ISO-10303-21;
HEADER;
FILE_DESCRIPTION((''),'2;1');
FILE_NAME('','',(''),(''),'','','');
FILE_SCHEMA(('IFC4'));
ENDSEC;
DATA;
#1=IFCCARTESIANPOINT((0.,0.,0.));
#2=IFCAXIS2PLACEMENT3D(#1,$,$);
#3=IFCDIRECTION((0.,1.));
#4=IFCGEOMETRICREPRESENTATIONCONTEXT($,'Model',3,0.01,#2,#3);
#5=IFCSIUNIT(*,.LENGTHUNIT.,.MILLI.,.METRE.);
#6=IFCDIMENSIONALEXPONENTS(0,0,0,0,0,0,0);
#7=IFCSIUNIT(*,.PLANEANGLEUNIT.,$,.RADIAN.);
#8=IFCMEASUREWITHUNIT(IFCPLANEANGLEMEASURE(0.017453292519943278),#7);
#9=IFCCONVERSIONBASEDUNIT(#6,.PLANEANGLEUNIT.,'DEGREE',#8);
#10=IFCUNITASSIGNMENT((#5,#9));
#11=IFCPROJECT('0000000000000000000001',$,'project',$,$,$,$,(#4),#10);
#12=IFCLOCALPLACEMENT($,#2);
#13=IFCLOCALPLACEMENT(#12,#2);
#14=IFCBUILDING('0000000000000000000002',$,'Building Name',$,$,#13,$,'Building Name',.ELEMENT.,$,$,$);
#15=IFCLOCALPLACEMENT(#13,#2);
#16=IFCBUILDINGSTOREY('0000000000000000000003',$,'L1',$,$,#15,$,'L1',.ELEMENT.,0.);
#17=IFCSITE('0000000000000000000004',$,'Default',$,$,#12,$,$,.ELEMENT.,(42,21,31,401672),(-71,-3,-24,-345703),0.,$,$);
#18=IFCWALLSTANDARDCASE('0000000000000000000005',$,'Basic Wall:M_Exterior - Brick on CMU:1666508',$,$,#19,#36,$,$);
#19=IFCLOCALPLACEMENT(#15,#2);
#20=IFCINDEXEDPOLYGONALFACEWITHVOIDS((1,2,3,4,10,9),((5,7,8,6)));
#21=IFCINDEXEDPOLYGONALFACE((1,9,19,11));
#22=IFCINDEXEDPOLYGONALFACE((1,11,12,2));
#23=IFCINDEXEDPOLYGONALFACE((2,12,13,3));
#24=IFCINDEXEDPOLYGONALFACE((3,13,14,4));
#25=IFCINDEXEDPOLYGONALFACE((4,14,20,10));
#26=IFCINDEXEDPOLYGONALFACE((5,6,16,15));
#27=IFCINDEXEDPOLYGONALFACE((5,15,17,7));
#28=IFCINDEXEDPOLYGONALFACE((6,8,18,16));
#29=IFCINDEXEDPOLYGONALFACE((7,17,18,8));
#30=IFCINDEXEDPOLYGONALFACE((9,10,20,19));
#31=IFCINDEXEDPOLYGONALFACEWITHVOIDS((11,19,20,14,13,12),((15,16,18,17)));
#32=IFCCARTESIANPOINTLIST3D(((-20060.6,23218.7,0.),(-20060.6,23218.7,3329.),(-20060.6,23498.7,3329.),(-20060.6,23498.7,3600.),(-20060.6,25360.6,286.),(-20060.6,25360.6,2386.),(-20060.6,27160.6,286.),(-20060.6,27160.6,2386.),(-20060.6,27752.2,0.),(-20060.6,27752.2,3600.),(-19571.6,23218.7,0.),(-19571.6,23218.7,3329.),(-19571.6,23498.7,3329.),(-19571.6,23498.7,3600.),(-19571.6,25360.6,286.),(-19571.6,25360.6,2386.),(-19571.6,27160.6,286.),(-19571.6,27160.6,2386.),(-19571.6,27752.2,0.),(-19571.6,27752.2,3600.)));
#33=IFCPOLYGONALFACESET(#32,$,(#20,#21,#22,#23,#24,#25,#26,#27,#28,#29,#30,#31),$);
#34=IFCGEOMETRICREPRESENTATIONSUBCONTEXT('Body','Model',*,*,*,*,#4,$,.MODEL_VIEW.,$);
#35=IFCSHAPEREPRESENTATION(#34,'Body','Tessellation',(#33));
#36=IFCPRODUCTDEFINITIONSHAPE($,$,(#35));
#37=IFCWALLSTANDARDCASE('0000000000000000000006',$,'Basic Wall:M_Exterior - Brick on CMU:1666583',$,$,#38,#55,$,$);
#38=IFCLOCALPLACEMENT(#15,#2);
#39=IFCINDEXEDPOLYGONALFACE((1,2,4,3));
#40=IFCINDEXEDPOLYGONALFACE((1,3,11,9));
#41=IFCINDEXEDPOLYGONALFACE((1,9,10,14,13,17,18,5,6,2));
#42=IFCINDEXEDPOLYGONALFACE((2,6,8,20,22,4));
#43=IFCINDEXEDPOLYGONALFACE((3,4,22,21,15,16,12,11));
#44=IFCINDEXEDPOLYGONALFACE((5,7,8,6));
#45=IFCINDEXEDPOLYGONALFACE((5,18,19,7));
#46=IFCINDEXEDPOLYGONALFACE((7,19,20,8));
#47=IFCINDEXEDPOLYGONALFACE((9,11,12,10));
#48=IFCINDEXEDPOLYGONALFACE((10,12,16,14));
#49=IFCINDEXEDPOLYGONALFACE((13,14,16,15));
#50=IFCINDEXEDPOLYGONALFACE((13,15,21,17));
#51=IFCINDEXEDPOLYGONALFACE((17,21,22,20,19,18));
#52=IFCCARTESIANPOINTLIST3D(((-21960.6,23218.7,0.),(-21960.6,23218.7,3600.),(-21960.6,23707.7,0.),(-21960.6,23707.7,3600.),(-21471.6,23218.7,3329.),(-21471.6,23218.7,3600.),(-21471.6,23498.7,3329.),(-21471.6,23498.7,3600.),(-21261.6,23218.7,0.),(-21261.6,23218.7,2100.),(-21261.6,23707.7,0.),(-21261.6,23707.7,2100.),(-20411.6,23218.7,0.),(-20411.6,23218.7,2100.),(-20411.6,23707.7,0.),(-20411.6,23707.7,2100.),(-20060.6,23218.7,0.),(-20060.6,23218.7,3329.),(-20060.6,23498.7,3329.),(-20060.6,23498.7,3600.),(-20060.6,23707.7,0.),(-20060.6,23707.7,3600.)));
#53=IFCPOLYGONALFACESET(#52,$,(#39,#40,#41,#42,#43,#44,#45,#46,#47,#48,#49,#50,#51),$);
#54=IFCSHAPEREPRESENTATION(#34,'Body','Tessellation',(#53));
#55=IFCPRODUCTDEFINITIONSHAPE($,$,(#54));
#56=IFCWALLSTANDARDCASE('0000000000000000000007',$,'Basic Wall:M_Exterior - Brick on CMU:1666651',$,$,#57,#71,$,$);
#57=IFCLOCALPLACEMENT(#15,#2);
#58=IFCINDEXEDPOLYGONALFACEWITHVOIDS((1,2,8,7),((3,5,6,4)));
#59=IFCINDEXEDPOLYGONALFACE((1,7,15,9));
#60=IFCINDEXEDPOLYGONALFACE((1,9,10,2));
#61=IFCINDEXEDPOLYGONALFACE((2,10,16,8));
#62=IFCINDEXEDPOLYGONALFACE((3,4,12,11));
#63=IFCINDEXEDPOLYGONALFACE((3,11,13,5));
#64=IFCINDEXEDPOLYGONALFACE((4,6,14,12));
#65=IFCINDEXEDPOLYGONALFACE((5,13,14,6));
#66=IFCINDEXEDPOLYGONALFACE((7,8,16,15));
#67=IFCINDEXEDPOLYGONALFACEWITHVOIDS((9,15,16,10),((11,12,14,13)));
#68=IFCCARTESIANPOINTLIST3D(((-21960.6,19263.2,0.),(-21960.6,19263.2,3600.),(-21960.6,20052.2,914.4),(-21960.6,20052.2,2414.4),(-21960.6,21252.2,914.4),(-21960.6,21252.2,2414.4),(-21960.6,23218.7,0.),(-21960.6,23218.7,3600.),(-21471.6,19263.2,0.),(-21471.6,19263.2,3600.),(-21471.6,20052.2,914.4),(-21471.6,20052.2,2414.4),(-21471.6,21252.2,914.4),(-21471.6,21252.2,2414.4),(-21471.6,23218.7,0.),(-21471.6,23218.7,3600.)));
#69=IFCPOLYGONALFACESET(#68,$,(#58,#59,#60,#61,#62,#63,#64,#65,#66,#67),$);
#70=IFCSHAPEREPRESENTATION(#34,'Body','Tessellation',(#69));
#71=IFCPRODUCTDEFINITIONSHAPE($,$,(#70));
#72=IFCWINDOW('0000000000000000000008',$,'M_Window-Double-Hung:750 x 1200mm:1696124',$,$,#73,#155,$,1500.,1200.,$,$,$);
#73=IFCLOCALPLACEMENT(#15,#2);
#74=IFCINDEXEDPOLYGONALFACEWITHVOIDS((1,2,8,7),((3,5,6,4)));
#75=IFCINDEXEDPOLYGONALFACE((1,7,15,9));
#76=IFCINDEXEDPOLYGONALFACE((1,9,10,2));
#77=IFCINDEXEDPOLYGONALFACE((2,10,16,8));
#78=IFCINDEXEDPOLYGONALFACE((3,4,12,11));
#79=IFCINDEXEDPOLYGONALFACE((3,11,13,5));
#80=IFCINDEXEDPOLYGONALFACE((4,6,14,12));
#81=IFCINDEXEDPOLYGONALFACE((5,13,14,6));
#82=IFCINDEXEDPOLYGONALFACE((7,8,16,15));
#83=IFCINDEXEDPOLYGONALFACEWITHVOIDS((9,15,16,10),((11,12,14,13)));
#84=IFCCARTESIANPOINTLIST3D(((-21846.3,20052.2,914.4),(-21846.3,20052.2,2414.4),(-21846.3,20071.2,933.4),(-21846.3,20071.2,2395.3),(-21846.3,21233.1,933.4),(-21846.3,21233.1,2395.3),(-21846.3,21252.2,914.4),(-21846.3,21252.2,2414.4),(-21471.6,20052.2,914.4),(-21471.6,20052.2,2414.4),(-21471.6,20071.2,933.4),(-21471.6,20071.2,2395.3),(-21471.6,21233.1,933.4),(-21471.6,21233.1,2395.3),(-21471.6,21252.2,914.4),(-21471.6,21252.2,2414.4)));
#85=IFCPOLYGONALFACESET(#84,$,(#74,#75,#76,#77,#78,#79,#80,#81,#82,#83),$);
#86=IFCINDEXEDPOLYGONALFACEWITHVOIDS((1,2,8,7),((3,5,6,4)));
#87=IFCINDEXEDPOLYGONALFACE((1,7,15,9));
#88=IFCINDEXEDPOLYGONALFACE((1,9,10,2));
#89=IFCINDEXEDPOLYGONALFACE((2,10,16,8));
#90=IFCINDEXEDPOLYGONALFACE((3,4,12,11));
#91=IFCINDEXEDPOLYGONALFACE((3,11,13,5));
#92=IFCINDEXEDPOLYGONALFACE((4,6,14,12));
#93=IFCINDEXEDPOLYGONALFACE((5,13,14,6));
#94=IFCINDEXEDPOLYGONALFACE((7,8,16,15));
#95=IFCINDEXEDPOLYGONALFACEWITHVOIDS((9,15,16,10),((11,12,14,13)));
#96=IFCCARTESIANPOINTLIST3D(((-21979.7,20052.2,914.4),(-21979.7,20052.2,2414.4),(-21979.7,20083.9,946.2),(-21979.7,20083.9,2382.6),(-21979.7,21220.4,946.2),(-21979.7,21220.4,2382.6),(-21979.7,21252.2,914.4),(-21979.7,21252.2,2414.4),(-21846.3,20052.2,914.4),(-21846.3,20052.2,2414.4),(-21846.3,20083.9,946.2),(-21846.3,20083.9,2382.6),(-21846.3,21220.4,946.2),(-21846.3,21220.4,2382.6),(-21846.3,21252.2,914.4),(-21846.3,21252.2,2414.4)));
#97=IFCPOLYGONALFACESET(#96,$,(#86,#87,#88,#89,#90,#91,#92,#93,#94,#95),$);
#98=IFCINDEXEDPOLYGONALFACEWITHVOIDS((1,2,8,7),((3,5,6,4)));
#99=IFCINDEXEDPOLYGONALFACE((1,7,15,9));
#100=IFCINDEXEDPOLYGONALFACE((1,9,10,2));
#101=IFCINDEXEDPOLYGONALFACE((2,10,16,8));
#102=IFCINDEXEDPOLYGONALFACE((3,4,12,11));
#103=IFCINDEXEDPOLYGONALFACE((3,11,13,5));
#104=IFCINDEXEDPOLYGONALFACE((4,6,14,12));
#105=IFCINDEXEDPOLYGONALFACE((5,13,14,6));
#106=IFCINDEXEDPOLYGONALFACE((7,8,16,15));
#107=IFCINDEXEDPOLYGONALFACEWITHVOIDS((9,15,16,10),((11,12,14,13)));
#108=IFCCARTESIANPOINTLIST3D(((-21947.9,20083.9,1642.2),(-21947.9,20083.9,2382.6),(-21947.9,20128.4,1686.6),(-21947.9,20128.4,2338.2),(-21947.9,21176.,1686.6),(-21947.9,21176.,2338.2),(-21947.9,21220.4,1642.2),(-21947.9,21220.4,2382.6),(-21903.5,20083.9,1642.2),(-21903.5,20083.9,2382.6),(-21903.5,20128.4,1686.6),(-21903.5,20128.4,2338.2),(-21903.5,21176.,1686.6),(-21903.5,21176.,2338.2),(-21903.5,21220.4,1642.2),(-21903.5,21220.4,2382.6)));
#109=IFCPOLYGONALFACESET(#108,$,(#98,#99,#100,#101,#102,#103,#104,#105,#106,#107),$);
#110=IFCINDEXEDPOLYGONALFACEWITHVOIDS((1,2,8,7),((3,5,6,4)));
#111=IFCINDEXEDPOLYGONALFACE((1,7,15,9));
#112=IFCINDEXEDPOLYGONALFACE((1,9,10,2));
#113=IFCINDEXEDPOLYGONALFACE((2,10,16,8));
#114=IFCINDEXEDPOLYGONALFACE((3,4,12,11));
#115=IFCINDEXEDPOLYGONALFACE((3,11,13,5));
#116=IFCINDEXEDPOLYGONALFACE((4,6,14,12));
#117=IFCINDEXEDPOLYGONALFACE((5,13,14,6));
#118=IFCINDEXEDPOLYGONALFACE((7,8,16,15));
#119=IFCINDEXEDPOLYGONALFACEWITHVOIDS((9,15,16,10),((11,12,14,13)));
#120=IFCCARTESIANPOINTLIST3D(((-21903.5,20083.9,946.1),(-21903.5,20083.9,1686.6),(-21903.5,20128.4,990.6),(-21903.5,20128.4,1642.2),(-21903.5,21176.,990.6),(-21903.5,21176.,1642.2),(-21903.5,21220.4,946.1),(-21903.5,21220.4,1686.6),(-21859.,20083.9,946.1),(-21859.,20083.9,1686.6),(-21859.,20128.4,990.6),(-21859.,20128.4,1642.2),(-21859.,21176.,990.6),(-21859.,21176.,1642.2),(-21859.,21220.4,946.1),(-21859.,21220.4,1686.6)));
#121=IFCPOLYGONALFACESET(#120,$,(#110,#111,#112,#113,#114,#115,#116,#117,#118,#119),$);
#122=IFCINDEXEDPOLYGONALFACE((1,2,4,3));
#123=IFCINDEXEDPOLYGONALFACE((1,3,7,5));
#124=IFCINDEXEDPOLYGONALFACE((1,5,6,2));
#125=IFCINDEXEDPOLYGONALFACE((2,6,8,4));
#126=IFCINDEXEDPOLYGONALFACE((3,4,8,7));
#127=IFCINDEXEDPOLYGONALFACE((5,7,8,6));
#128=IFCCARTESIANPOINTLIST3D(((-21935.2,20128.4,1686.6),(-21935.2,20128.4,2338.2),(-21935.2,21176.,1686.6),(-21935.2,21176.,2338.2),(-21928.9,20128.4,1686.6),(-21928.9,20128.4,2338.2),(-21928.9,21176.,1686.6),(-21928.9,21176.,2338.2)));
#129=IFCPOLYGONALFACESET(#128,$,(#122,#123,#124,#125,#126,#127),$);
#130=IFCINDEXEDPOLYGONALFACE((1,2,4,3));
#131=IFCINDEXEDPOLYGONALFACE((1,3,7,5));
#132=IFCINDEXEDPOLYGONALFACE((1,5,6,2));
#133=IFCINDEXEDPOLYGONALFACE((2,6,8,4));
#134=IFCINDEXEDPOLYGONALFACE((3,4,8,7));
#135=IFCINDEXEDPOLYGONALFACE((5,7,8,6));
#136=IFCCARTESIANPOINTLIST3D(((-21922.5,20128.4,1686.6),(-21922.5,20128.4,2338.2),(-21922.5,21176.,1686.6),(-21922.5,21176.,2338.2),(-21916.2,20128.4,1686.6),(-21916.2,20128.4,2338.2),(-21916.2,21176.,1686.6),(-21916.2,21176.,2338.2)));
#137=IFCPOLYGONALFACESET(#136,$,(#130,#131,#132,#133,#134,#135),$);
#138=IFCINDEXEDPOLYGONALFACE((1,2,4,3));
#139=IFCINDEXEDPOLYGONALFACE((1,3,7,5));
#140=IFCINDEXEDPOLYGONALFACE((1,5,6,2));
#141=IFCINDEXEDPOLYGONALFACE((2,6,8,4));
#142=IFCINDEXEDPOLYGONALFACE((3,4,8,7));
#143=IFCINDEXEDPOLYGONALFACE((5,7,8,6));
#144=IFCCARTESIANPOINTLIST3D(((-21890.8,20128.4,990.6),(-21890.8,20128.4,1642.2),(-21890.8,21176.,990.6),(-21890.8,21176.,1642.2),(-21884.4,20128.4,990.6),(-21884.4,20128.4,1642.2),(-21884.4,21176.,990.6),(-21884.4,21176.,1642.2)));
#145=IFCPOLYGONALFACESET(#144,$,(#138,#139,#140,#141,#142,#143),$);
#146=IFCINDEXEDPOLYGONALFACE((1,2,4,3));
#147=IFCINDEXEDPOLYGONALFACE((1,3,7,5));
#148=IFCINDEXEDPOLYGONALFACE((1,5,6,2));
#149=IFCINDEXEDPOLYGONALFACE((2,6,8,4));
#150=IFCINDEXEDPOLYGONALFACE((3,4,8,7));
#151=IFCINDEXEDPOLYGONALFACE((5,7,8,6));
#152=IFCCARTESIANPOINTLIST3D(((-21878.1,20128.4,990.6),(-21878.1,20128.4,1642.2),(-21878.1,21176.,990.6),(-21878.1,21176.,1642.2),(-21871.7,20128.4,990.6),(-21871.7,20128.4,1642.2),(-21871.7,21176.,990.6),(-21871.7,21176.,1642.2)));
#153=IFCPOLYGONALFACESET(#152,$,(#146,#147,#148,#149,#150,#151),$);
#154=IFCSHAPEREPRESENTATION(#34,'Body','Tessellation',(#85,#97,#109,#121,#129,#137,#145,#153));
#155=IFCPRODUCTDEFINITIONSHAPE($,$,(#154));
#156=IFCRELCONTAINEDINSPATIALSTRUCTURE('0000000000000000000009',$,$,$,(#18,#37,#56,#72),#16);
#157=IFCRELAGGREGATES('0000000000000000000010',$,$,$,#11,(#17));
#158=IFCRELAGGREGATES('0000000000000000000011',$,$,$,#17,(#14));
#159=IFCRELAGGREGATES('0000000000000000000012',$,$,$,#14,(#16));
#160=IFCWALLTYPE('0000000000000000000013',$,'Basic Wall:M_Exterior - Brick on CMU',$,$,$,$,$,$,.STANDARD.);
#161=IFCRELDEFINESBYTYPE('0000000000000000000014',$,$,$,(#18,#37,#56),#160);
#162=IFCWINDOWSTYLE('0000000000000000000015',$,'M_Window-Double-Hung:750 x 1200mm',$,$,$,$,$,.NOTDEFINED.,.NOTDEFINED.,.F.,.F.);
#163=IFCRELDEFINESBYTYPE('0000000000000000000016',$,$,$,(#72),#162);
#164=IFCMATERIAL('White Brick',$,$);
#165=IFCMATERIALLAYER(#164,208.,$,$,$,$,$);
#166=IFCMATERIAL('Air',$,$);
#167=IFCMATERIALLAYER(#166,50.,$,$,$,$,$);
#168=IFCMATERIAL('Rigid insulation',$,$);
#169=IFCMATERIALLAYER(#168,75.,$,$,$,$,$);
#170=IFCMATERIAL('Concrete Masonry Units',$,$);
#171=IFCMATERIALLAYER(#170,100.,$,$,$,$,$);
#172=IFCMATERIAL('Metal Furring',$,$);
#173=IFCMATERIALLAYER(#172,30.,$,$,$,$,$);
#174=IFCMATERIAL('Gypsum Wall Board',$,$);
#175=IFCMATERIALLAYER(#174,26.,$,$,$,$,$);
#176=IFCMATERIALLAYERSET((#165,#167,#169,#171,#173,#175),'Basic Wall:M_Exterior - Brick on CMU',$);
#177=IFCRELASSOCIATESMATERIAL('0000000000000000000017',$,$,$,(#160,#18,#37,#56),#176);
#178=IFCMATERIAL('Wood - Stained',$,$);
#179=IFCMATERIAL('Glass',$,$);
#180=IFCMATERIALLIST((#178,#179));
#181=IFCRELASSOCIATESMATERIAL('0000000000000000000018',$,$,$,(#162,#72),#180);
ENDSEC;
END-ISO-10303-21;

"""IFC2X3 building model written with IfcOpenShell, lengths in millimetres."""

from ifc_helpers import new_model, entity, si_unit, converted_unit, direction, frame, frame_2d, origin, place, context, subcontext, project, spatial, polyline, rectangle, outline, extrude, clip, bounded_halfspace, source, transform, mapped, material, material_list, layer, layer_set, layer_usage, type_object, type_shapes, element, fill, save


model = new_model("IFC2X3")

# Units and contexts
model_context = context("Model", 3, precision=0.01, world=origin(), true_north=direction((0.0, 1.0)))
body_context = subcontext(model_context, "Body", "Model", "MODEL_VIEW")
ifc_project = project(units=[si_unit("LENGTHUNIT", "METRE", prefix="MILLI"), converted_unit("PLANEANGLEUNIT", "DEGREE", entity("IfcPlaneAngleMeasure", 0.017453292519943278), si_unit("PLANEANGLEUNIT", "RADIAN"), dimensions=[0, 0, 0, 0, 0, 0, 0])], contexts=[model_context])

# Site, building, storey
site_placement = place(None, origin())
site = spatial("IfcSite", under=ifc_project, at=site_placement, Name="Default", CompositionType="ELEMENT", RefLatitude=(42, 21, 31, 401672), RefLongitude=(-71, -3, -24, -345703), RefElevation=0.0)
building_placement = place(site_placement, origin())
building = spatial("IfcBuilding", under=site, at=building_placement, Name="Building Name", LongName="Building Name", CompositionType="ELEMENT")
storey_placement = place(building_placement, origin())
storey = spatial("IfcBuildingStorey", under=building, at=storey_placement, Name="L1", LongName="L1", CompositionType="ELEMENT", Elevation=0.0)

# Walls, openings
ifc_material_1 = material(Name="White Brick")
ifc_layer_1 = layer(ifc_material_1, 208.0)
ifc_material_2 = material(Name="Air")
ifc_layer_2 = layer(ifc_material_2, 50.0)
ifc_material_3 = material(Name="Rigid insulation")
ifc_layer_3 = layer(ifc_material_3, 75.0)
ifc_material_4 = material(Name="Concrete Masonry Units")
ifc_layer_4 = layer(ifc_material_4, 100.0)
ifc_material_5 = material(Name="Metal Furring")
ifc_layer_5 = layer(ifc_material_5, 30.0)
ifc_material_6 = material(Name="Gypsum Wall Board")
ifc_layer_6 = layer(ifc_material_6, 26.0)
ifc_layer_set_1 = layer_set([ifc_layer_1, ifc_layer_2, ifc_layer_3, ifc_layer_4, ifc_layer_5, ifc_layer_6], Name="Basic Wall:M_Exterior - Brick on CMU")
ifc_layer_usage_1 = layer_usage(ifc_layer_set_1, "AXIS2", "POSITIVE", -244.5)
wall_type_1 = type_object("IfcWallType", Name="Basic Wall:M_Exterior - Brick on CMU", PredefinedType="STANDARD", material=ifc_layer_set_1)
wall_1_placement = place(storey_placement, frame((-19816.1, 27752.2, 0.0), z_axis=(0.0, 0.0, 1.0), x_axis=(0.0, -1.0, 0.0)))
wall_1 = element("IfcWallStandardCase", 1, at=wall_1_placement, inside=storey, type_object=wall_type_1, material=ifc_layer_usage_1, Name="Basic Wall:M_Exterior - Brick on CMU:1666508", context=body_context, shape_type="Clipping", body=[
    clip(extrude(rectangle(XDim=4533.5, YDim=489.0, at=frame_2d((2266.8, 0.0), x_axis=(-1.0, 0.0))), origin(), (0.0, 0.0, 1.0), 3600.0), bounded_halfspace(frame((4253.5, -244.5, 3329.0), z_axis=(0.0, 0.0, -1.0), x_axis=(1.0, 0.0, 0.0)), True, frame((4253.5, -244.5, 3329.0)), polyline([(0.0, 0.0), (280.0, 0.0), (280.0, 90.0), (280.0, 489.0), (0.0, 489.0), (0.0, 0.0)]))),
])
opening_1_placement = place(wall_1_placement, frame((2391.5, 244.5, 286.0)))
element("IfcOpeningElement", 2, at=opening_1_placement, cuts=wall_1, ObjectType="Opening", context=body_context, shape_type="SweptSolid", body=[
    extrude(rectangle(XDim=2100.0, YDim=1800.0, at=frame_2d((1050.0, 900.0), x_axis=(1.0, 0.0))), frame((0.0, 0.0, 0.0), z_axis=(0.0, -1.0, 0.0), x_axis=(0.0, 0.0, 1.0)), (0.0, 0.0, 1.0), 489.0),
])
ifc_layer_usage_2 = layer_usage(ifc_layer_set_1, "AXIS2", "POSITIVE", -244.5)
wall_2_placement = place(storey_placement, frame((-20060.6, 23463.2, 0.0), z_axis=(0.0, 0.0, 1.0), x_axis=(-1.0, 0.0, 0.0)))
wall_2 = element("IfcWallStandardCase", 3, at=wall_2_placement, inside=storey, type_object=wall_type_1, material=ifc_layer_usage_2, Name="Basic Wall:M_Exterior - Brick on CMU:1666583", context=body_context, shape_type="Clipping", body=[
    clip(extrude(rectangle(XDim=1900.0, YDim=489.0, at=frame_2d((950.0, 0.0), x_axis=(-1.0, 0.0))), origin(), (0.0, 0.0, 1.0), 3600.0), bounded_halfspace(frame((1411.0, -35.5, 3329.0), z_axis=(0.0, 0.0, -1.0), x_axis=(0.0, 1.0, 0.0)), True, frame((1411.0, -35.5, 3329.0)), polyline([(0.0, 0.0), (0.0, 280.0), (-1380.0, 280.0), (-1411.0, 280.0), (-1411.0, 0.0), (0.0, 0.0)]))),
])
opening_2_placement = place(wall_2_placement, frame((1201.0, 244.5, 0.0)))
element("IfcOpeningElement", 4, at=opening_2_placement, cuts=wall_2, ObjectType="Opening", context=body_context, shape_type="SweptSolid", body=[
    extrude(rectangle(XDim=2100.0, YDim=850.0, at=frame_2d((1050.0, 425.0), x_axis=(1.0, 0.0))), frame((0.0, 0.0, 0.0), z_axis=(0.0, -1.0, 0.0), x_axis=(0.0, 0.0, 1.0)), (0.0, 0.0, 1.0), 489.0),
])

# Wall, opening, window
ifc_layer_usage_3 = layer_usage(ifc_layer_set_1, "AXIS2", "POSITIVE", -244.5)
wall_3_placement = place(storey_placement, frame((-21716.1, 23218.7, 0.0), z_axis=(0.0, 0.0, 1.0), x_axis=(0.0, -1.0, 0.0)))
wall_3 = element("IfcWallStandardCase", 5, at=wall_3_placement, inside=storey, type_object=wall_type_1, material=ifc_layer_usage_3, Name="Basic Wall:M_Exterior - Brick on CMU:1666651", context=body_context, shape_type="SweptSolid", body=[
    extrude(rectangle(XDim=3955.5, YDim=489.0, at=frame_2d((1977.8, 0.0), x_axis=(-1.0, 0.0))), origin(), (0.0, 0.0, 1.0), 3600.0),
])
opening_3_placement = place(wall_3_placement, frame((3166.5, 244.5, 914.4)))
opening_3 = element("IfcOpeningElement", 6, at=opening_3_placement, cuts=wall_3, ObjectType="Opening", context=body_context, shape_type="SweptSolid", body=[
    extrude(rectangle(XDim=1500.0, YDim=1200.0, at=frame_2d((750.0, 600.0), x_axis=(-1.0, 0.0))), frame((0.0, 0.0, 0.0), z_axis=(0.0, -1.0, 0.0), x_axis=(0.0, 0.0, 1.0)), (0.0, 0.0, 1.0), 489.0),
])
ifc_material_7 = material(Name="Wood - Stained")
ifc_material_8 = material(Name="Glass")
ifc_material_list_1 = material_list([ifc_material_7, ifc_material_8])
window_style = type_object("IfcWindowStyle", Name="M_Window-Double-Hung:750 x 1200mm", ConstructionType="NOTDEFINED", OperationType="NOTDEFINED", ParameterTakesPrecedence=False, Sizeable=False, material=ifc_material_list_1)
shared_shape_1 = source(origin(), body_context, "Body", "SweptSolid", [
    extrude(outline(polyline([(-750.0, -600.0), (750.0, -600.0), (750.0, 600.0), (-750.0, 600.0), (-750.0, -600.0)]), holes=[polyline([(-730.9, -580.9), (-730.9, 580.9), (730.9, 580.9), (730.9, -580.9), (-730.9, -580.9)])]), frame((600.0, 0.0, 750.0), z_axis=(0.0, 1.0, 0.0), x_axis=(0.0, 0.0, -1.0)), (0.0, 0.0, 1.0), 374.7),
    extrude(outline(polyline([(-600.0, -750.0), (600.0, -750.0), (600.0, 750.0), (-600.0, 750.0), (-600.0, -750.0)]), holes=[polyline([(568.2, -718.2), (-568.2, -718.2), (-568.2, 718.2), (568.2, 718.2), (568.2, -718.2)])]), frame((600.0, 374.7, 750.0), z_axis=(0.0, 1.0, 0.0), x_axis=(1.0, 0.0, 0.0)), (0.0, 0.0, 1.0), 133.3),
    extrude(outline(polyline([(-568.2, -370.2), (568.2, -370.2), (568.2, 370.2), (-568.2, 370.2), (-568.2, -370.2)]), holes=[polyline([(523.8, -325.8), (-523.8, -325.8), (-523.8, 325.8), (523.8, 325.8), (523.8, -325.8)])]), frame((600.0, 431.8, 1098.0), z_axis=(0.0, 1.0, 0.0), x_axis=(1.0, 0.0, 0.0)), (0.0, 0.0, 1.0), 44.4),
    extrude(outline(polyline([(-568.2, -370.2), (568.2, -370.2), (568.2, 370.2), (-568.2, 370.2), (-568.2, -370.2)]), holes=[polyline([(523.8, -325.8), (-523.8, -325.8), (-523.8, 325.8), (523.8, 325.8), (523.8, -325.8)])]), frame((600.0, 387.4, 402.0), z_axis=(0.0, 1.0, 0.0), x_axis=(1.0, 0.0, 0.0)), (0.0, 0.0, 1.0), 44.5),
    extrude(rectangle(XDim=1047.6, YDim=6.4, at=frame_2d((0.0, 0.0), x_axis=(1.0, 0.0))), frame((600.0, 460.4, 772.2), z_axis=(0.0, 0.0, 1.0), x_axis=(-1.0, 0.0, 0.0)), (0.0, 0.0, 1.0), 651.6),
    extrude(rectangle(XDim=6.4, YDim=1047.6, at=frame_2d((0.0, 0.0), x_axis=(1.0, 0.0))), frame((600.0, 447.7, 772.2), z_axis=(0.0, 0.0, 1.0), x_axis=(0.0, -1.0, 0.0)), (0.0, 0.0, 1.0), 651.6),
    extrude(rectangle(XDim=1047.6, YDim=6.4, at=frame_2d((0.0, 0.0), x_axis=(1.0, 0.0))), frame((600.0, 416.0, 76.2), z_axis=(0.0, 0.0, 1.0), x_axis=(-1.0, 0.0, 0.0)), (0.0, 0.0, 1.0), 651.6),
    extrude(rectangle(XDim=6.4, YDim=1047.6, at=frame_2d((0.0, 0.0), x_axis=(1.0, 0.0))), frame((600.0, 403.3, 76.2), z_axis=(0.0, 0.0, 1.0), x_axis=(0.0, -1.0, 0.0)), (0.0, 0.0, 1.0), 651.6),
])
type_shapes(window_style, [shared_shape_1])
window_placement = place(opening_3_placement, frame((0.0, 0.0, 0.0), z_axis=(0.0, 0.0, 1.0), x_axis=(-1.0, 0.0, 0.0)))
window = element("IfcWindow", 7, at=window_placement, inside=storey, type_object=window_style, material=ifc_material_list_1, Name="M_Window-Double-Hung:750 x 1200mm:1696124", OverallHeight=1500.0, OverallWidth=1200.0, context=body_context, shape_type="MappedRepresentation", body=[
    mapped(shared_shape_1, transform((0.0, 0.0, 0.0), scale=1.0)),
])
fill(opening_3, window)

save(model, "model.ifc")
